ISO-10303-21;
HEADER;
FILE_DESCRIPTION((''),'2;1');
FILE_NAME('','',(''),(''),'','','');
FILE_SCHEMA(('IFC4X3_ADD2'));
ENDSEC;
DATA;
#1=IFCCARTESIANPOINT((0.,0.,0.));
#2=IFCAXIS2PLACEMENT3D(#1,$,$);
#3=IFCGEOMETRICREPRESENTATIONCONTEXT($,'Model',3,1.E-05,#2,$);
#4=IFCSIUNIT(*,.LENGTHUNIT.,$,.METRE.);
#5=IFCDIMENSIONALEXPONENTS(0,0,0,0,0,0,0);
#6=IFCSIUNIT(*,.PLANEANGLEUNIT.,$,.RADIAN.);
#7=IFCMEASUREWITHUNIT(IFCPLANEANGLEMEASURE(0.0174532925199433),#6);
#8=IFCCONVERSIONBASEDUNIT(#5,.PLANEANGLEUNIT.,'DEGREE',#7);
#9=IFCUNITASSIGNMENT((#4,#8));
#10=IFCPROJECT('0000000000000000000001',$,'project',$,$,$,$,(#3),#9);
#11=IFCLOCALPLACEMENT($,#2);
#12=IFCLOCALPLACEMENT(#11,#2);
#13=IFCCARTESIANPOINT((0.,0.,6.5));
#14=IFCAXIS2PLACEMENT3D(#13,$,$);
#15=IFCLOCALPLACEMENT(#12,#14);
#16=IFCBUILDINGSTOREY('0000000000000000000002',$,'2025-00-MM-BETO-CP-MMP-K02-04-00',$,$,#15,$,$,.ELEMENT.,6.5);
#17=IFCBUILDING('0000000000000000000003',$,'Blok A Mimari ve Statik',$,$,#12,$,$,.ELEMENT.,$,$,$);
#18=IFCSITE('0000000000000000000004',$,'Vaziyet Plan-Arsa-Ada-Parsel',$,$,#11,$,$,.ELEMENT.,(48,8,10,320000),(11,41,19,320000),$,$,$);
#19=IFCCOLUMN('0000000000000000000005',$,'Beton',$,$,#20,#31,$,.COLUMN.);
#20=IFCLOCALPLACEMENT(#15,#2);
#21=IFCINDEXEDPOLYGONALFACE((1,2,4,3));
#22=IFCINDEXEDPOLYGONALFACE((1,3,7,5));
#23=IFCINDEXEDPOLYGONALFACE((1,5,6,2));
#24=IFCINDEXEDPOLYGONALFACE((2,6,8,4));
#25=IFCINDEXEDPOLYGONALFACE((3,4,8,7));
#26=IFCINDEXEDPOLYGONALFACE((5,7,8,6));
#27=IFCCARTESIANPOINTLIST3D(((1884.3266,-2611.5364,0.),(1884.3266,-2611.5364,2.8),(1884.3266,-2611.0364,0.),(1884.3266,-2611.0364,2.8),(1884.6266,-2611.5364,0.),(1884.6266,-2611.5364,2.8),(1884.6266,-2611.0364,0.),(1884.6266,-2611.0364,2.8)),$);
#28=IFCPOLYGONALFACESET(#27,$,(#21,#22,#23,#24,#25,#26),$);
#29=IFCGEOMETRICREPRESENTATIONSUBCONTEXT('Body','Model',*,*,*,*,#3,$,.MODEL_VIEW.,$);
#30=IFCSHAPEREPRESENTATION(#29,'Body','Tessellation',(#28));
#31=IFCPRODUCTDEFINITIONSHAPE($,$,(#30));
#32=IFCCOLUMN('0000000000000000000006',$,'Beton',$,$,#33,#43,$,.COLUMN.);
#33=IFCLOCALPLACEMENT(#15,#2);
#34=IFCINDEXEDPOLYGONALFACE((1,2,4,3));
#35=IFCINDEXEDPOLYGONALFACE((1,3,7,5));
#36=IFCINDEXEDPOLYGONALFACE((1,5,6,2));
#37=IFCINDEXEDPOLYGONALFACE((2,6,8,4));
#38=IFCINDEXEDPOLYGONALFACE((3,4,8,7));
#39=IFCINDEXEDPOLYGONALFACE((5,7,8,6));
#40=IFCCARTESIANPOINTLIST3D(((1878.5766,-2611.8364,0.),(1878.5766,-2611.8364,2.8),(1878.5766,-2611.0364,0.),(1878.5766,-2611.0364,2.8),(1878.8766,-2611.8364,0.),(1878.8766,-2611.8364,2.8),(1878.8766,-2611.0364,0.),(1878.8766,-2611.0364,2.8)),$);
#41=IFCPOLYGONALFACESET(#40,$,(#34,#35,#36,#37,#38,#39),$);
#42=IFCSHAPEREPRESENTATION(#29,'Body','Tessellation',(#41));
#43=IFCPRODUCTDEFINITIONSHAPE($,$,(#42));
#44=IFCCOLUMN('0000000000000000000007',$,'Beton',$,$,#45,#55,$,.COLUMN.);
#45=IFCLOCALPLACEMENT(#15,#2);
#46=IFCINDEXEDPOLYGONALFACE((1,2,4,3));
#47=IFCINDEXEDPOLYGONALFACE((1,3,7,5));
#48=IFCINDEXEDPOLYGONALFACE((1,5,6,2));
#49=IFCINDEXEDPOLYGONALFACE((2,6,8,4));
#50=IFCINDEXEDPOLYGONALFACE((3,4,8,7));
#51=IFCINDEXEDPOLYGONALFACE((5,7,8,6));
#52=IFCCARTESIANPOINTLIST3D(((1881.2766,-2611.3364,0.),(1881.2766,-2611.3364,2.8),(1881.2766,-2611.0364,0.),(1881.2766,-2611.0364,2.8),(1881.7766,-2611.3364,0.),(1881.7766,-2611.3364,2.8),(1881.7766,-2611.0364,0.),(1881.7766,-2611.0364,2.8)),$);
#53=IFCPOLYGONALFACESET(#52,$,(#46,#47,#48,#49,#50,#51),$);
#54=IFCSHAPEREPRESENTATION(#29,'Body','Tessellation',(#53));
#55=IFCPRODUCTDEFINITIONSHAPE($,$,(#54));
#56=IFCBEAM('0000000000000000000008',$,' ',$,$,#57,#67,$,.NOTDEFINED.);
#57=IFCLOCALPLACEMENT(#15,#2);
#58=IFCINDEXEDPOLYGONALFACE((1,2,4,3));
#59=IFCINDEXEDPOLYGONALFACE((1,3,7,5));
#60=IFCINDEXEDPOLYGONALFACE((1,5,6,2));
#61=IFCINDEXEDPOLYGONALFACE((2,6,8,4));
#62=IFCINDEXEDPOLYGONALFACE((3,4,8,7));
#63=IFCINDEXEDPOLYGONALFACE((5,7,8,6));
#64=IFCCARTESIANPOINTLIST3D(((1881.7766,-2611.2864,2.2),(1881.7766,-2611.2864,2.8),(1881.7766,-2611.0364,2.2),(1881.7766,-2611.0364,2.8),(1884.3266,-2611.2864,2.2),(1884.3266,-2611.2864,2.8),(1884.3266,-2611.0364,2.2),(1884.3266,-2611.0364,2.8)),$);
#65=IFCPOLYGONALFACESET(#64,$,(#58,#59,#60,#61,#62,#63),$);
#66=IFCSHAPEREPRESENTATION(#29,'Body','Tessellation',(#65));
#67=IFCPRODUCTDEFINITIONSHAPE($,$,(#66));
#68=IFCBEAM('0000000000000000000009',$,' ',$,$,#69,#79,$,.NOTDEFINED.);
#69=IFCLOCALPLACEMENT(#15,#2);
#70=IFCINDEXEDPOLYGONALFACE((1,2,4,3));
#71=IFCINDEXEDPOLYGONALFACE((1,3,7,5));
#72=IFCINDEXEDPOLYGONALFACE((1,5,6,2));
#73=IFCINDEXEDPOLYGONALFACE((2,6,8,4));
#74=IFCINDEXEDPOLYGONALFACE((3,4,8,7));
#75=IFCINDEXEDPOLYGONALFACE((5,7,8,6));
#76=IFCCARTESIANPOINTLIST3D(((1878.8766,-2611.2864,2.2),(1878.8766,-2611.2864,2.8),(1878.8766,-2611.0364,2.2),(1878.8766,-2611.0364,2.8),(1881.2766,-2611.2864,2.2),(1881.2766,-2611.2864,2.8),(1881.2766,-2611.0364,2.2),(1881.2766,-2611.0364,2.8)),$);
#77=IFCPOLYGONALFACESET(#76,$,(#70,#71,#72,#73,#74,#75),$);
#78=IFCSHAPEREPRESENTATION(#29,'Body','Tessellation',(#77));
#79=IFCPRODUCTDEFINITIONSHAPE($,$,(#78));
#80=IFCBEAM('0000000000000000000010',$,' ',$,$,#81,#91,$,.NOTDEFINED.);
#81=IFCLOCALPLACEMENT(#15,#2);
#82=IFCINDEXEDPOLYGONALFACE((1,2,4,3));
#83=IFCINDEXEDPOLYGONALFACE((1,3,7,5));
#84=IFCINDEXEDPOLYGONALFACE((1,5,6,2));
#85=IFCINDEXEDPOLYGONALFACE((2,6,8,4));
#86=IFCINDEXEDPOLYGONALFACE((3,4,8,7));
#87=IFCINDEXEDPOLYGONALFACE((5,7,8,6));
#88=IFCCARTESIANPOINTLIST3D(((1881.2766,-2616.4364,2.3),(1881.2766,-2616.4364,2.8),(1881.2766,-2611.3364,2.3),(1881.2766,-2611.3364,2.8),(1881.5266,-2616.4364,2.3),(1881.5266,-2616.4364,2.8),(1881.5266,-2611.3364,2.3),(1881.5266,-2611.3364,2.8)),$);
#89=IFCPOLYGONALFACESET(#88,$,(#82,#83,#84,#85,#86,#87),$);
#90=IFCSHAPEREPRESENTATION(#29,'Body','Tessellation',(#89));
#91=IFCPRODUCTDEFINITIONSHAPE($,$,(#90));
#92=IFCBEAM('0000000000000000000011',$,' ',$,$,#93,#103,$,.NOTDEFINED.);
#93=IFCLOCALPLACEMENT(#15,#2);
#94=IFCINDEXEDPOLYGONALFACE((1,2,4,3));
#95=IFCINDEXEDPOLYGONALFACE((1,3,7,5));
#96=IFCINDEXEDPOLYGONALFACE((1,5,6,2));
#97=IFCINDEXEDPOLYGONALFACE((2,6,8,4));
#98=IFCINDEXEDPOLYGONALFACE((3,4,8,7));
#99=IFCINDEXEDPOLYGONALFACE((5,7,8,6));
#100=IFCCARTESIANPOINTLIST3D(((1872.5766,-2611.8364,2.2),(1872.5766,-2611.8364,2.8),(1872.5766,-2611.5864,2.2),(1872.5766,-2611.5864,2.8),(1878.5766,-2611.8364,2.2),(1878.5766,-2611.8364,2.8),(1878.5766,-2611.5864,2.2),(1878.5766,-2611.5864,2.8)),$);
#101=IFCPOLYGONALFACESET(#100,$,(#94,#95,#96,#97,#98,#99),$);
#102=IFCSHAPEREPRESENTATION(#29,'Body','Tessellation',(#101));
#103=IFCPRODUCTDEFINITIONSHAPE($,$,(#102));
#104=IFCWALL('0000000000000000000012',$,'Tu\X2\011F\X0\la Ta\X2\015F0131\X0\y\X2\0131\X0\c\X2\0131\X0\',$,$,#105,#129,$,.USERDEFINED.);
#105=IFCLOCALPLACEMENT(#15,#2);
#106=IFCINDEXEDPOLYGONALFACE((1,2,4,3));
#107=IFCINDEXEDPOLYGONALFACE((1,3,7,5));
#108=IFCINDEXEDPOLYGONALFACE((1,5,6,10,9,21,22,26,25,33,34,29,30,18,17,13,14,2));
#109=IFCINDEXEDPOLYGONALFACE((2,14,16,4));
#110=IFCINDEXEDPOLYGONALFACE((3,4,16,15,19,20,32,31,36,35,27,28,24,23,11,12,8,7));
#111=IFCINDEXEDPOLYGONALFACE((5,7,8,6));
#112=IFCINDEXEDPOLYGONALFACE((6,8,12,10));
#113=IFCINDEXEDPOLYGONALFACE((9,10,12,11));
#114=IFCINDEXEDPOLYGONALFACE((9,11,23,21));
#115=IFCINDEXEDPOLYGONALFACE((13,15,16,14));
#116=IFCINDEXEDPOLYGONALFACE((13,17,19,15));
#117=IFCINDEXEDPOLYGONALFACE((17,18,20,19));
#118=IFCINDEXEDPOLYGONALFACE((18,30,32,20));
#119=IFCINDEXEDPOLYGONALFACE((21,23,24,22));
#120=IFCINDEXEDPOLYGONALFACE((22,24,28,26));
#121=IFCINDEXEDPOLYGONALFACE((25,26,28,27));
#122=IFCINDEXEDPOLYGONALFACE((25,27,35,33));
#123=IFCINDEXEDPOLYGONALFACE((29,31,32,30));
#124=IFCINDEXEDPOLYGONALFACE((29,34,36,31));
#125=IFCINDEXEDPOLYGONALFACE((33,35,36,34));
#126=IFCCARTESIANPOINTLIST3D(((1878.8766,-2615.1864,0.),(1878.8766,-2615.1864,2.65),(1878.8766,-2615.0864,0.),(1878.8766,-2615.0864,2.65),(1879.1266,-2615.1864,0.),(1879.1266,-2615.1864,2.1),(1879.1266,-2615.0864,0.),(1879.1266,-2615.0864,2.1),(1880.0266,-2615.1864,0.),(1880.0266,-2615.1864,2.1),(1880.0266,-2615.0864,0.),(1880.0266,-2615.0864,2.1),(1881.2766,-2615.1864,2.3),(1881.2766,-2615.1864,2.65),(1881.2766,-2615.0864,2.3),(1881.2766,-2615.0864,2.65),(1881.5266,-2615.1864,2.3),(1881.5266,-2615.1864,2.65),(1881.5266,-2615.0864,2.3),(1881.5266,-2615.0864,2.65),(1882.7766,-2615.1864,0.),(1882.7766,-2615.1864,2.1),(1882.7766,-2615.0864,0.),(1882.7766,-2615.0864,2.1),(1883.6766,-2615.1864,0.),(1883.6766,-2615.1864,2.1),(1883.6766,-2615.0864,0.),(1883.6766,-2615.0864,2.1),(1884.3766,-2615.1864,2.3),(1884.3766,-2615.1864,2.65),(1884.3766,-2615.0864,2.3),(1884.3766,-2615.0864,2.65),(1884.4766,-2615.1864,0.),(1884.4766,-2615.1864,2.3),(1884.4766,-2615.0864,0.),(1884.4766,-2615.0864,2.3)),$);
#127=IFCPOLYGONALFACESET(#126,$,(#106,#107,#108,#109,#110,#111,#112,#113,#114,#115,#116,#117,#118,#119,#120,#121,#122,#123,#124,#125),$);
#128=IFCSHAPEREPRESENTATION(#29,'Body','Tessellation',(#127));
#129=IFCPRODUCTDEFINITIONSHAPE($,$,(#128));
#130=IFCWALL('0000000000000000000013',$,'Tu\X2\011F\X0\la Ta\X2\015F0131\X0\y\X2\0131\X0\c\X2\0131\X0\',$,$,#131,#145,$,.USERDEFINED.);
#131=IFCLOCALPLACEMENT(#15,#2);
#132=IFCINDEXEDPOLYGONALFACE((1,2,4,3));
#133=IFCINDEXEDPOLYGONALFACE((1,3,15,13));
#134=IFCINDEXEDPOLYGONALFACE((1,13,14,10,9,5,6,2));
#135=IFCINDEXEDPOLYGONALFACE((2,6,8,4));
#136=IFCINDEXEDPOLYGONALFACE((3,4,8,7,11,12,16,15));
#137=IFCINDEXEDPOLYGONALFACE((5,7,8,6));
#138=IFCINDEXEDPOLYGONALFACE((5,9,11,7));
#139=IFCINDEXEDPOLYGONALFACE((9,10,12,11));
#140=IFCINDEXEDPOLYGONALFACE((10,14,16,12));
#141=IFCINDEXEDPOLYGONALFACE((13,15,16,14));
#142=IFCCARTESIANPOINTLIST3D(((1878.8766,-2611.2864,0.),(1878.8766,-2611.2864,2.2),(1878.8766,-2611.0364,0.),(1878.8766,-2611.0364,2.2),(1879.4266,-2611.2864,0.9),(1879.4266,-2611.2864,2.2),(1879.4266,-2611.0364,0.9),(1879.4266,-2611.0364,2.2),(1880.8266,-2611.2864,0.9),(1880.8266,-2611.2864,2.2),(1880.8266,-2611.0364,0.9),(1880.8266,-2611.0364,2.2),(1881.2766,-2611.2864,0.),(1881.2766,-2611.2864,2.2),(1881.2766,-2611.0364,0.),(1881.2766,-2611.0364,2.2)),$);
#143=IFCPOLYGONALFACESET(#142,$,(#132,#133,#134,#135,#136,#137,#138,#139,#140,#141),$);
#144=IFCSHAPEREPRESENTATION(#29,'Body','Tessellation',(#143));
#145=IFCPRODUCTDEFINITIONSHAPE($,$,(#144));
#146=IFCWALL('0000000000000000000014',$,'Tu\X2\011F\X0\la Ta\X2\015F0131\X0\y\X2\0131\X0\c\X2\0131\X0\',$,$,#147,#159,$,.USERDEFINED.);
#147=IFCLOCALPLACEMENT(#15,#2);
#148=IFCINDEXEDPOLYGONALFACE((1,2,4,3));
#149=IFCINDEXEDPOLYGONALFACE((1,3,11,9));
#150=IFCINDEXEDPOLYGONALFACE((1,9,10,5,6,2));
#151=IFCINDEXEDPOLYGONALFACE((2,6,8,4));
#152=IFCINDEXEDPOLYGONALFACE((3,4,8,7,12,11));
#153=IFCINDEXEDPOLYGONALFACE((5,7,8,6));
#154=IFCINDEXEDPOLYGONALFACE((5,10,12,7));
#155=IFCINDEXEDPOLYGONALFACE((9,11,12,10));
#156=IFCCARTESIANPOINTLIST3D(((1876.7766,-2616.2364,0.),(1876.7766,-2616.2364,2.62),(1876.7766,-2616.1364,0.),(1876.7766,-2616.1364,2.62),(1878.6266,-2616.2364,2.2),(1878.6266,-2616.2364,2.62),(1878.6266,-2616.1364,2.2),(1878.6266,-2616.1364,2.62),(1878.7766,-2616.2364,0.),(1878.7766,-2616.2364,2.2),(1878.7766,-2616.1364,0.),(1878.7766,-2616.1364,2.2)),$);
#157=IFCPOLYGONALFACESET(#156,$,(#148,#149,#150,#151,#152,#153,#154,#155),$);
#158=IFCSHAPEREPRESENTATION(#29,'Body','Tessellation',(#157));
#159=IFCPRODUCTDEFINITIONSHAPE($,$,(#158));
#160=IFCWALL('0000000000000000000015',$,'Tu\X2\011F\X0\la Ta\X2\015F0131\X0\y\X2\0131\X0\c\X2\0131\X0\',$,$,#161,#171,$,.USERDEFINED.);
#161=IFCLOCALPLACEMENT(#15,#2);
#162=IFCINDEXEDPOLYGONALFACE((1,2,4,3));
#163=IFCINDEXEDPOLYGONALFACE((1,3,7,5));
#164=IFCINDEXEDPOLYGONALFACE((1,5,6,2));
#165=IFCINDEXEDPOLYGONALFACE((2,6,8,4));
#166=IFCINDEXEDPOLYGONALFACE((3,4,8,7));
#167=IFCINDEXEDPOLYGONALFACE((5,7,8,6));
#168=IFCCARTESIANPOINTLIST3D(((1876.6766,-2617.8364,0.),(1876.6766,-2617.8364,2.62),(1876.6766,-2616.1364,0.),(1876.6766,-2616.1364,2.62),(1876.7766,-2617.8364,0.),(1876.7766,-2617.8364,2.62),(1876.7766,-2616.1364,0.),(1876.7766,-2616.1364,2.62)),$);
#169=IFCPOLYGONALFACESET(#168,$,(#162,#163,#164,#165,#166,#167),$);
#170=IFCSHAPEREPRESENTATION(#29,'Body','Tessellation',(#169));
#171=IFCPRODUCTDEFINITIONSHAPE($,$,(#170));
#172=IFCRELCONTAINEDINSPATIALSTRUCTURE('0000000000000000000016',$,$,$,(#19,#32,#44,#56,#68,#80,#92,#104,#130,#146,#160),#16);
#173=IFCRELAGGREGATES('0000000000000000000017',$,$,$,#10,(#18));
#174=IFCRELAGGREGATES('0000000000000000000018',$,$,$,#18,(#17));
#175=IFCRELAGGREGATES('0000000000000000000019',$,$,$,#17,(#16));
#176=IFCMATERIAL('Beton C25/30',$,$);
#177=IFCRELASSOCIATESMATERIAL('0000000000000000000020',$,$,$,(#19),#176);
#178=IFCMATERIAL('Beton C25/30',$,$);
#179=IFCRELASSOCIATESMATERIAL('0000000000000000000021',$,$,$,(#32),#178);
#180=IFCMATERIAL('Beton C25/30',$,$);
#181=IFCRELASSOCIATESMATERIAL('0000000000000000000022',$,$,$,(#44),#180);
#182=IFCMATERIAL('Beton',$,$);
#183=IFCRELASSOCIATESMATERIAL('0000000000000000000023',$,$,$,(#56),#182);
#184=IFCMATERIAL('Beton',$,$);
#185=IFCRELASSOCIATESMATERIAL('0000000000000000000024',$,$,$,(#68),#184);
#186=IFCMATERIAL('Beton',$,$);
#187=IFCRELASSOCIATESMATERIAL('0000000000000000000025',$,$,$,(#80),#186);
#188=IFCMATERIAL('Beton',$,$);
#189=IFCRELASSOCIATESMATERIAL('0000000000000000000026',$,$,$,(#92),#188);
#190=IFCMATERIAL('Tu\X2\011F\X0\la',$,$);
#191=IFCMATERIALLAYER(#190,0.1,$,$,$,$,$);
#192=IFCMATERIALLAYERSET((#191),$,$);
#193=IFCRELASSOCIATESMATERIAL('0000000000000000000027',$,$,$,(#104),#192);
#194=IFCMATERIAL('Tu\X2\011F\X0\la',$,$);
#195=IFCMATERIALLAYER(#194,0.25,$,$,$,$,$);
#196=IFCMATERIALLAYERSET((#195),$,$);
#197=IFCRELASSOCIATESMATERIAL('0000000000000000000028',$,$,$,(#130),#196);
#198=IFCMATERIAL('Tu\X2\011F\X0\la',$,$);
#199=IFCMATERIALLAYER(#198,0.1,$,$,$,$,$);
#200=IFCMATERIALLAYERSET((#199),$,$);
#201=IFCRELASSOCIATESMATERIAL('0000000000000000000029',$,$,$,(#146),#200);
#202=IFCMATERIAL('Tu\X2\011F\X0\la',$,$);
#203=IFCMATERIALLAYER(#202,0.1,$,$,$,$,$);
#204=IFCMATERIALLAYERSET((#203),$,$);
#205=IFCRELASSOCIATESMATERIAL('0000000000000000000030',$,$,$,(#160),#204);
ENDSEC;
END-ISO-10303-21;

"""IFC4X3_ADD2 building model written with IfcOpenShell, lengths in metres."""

from ifc_helpers import new_model, entity, si_unit, converted_unit, frame, frame_2d, origin, origin_with_axes, place, context, subcontext, project, spatial, polyline, rectangle, outline, extrude, clip, bounded_halfspace, material, layer, layer_set, layer_usage, element, save


model = new_model("IFC4X3_ADD2")

# Units and contexts
model_context = context("Model", 3, precision=1e-05, world=origin())
body_context = subcontext(model_context, "Body", "Model", "MODEL_VIEW")
ifc_project = project(units=[si_unit("LENGTHUNIT", "METRE"), converted_unit("PLANEANGLEUNIT", "DEGREE", entity("IfcPlaneAngleMeasure", 0.0174532925199433), si_unit("PLANEANGLEUNIT", "RADIAN"), dimensions=[0, 0, 0, 0, 0, 0, 0])], contexts=[model_context])

# Site, building, storey
site_placement = place(None, origin())
site = spatial("IfcSite", under=ifc_project, at=site_placement, Name="Vaziyet Plan-Arsa-Ada-Parsel", CompositionType="ELEMENT", RefLatitude=(48, 8, 10, 320000), RefLongitude=(11, 41, 19, 320000))
building_placement = place(site_placement, origin())
building = spatial("IfcBuilding", under=site, at=building_placement, Name="Blok A Mimari ve Statik", CompositionType="ELEMENT")
storey_placement = place(building_placement, frame((0.0, 0.0, 6.5)))
storey = spatial("IfcBuildingStorey", under=building, at=storey_placement, Name="2025-00-MM-BETO-CP-MMP-K02-04-00", CompositionType="ELEMENT", Elevation=6.5)

# Columns
ifc_material_1 = material(Name="Beton C25/30")
column_1_placement = place(storey_placement, frame((1884.3266, -2611.5364, 0.0)))
element("IfcColumn", 1, at=column_1_placement, inside=storey, material=ifc_material_1, Name="Beton", PredefinedType="COLUMN", context=body_context, shape_type="SweptSolid", body=[
    extrude(outline(polyline([(0.0, 0.5), (0.0, 0.0), (0.3, 0.0), (0.3, 0.5), (0.0, 0.5)])), origin_with_axes(), (0.0, 0.0, 1.0), 2.8),
])
ifc_material_2 = material(Name="Beton C25/30")
column_2_placement = place(storey_placement, frame((1878.5766, -2611.8364, 0.0)))
element("IfcColumn", 2, at=column_2_placement, inside=storey, material=ifc_material_2, Name="Beton", PredefinedType="COLUMN", context=body_context, shape_type="SweptSolid", body=[
    extrude(outline(polyline([(0.0, 0.0), (0.3, 0.0), (0.3, 0.8), (0.0, 0.8), (0.0, 0.0)])), origin_with_axes(), (0.0, 0.0, 1.0), 2.8),
])
ifc_material_3 = material(Name="Beton C25/30")
column_3_placement = place(storey_placement, frame((1881.2766, -2611.3364, 0.0)))
element("IfcColumn", 3, at=column_3_placement, inside=storey, material=ifc_material_3, Name="Beton", PredefinedType="COLUMN", context=body_context, shape_type="SweptSolid", body=[
    extrude(outline(polyline([(0.0, 0.3), (0.0, 0.0), (0.5, 0.0), (0.5, 0.3), (0.0, 0.3)])), origin_with_axes(), (0.0, 0.0, 1.0), 2.8),
])

# Beams
ifc_material_4 = material(Name="Beton")
beam_1_placement = place(storey_placement, frame((1884.3266, -2611.0364, 2.2), z_axis=(0.0, 0.0, 1.0), x_axis=(-1.0, 0.0, 0.0)))
element("IfcBeam", 4, at=beam_1_placement, inside=storey, material=ifc_material_4, Name=" ", PredefinedType="NOTDEFINED", context=body_context, shape_type="SweptSolid", body=[
    extrude(rectangle(XDim=0.25, YDim=0.6, at=frame_2d((0.125, 0.3), x_axis=(1.0, 0.0))), frame((0.0, 0.0, 0.0), z_axis=(1.0, 0.0, 0.0), x_axis=(0.0, 1.0, 0.0)), (0.0, 0.0, 1.0), 2.55),
])
ifc_material_5 = material(Name="Beton")
beam_2_placement = place(storey_placement, frame((1881.2766, -2611.0364, 2.2), z_axis=(0.0, 0.0, 1.0), x_axis=(-1.0, 0.0, 0.0)))
element("IfcBeam", 5, at=beam_2_placement, inside=storey, material=ifc_material_5, Name=" ", PredefinedType="NOTDEFINED", context=body_context, shape_type="SweptSolid", body=[
    extrude(rectangle(XDim=0.25, YDim=0.6, at=frame_2d((0.125, 0.3), x_axis=(1.0, 0.0))), frame((0.0, 0.0, 0.0), z_axis=(1.0, 0.0, 0.0), x_axis=(0.0, 1.0, 0.0)), (0.0, 0.0, 1.0), 2.4),
])
ifc_material_6 = material(Name="Beton")
beam_3_placement = place(storey_placement, frame((1881.2766, -2611.3364, 2.3), z_axis=(0.0, 0.0, 1.0), x_axis=(0.0, -1.0, 0.0)))
element("IfcBeam", 6, at=beam_3_placement, inside=storey, material=ifc_material_6, Name=" ", PredefinedType="NOTDEFINED", context=body_context, shape_type="SweptSolid", body=[
    extrude(rectangle(XDim=0.25, YDim=0.5, at=frame_2d((0.125, 0.25), x_axis=(1.0, 0.0))), frame((0.0, 0.0, 0.0), z_axis=(1.0, 0.0, 0.0), x_axis=(0.0, 1.0, 0.0)), (0.0, 0.0, 1.0), 5.1),
])
ifc_material_7 = material(Name="Beton")
beam_4_placement = place(storey_placement, frame((1878.5766, -2611.5864, 2.2), z_axis=(0.0, 0.0, 1.0), x_axis=(-1.0, 0.0, 0.0)))
element("IfcBeam", 7, at=beam_4_placement, inside=storey, material=ifc_material_7, Name=" ", PredefinedType="NOTDEFINED", context=body_context, shape_type="SweptSolid", body=[
    extrude(rectangle(XDim=0.25, YDim=0.6, at=frame_2d((0.125, 0.3), x_axis=(1.0, 0.0))), frame((0.0, 0.0, 0.0), z_axis=(1.0, 0.0, 0.0), x_axis=(0.0, 1.0, 0.0)), (0.0, 0.0, 1.0), 6.0),
])

# Wall, openings
ifc_material_8 = material(Name="Tuğla")
ifc_layer_1 = layer(ifc_material_8, 0.1)
ifc_layer_set_1 = layer_set([ifc_layer_1])
ifc_layer_usage_1 = layer_usage(ifc_layer_set_1, "AXIS2", "POSITIVE", 0.0)
wall_1_placement = place(storey_placement, frame((1878.8766, -2615.1864, 0.0), z_axis=(0.0, 0.0, 1.0), x_axis=(1.0, 0.0, 0.0)))
wall_1 = element("IfcWall", 8, at=wall_1_placement, inside=storey, material=ifc_layer_usage_1, Name="Tuğla Taşıyıcı", PredefinedType="USERDEFINED", context=body_context, shape_type="Clipping", body=[
    clip(clip(extrude(rectangle(XDim=5.6, YDim=0.1, at=frame_2d((2.8, 0.05), x_axis=(1.0, 0.0))), origin_with_axes(), (0.0, 0.0, 1.0), 2.65), bounded_halfspace(frame((2.525, 0.05, 2.3), z_axis=(0.0, 0.0, -1.0), x_axis=(0.0, -1.0, 0.0)), True, origin_with_axes(), polyline([(2.4, 0.1), (2.4, 0.0), (2.65, 0.0), (2.65, 0.1), (2.4, 0.1)]))), bounded_halfspace(frame((5.55, 0.05, 2.3), z_axis=(0.0, 0.0, -1.0), x_axis=(0.0, -1.0, 0.0)), True, origin_with_axes(), polyline([(5.5, 0.1), (5.5, 0.0), (5.6, 0.0), (5.6, 0.1), (5.5, 0.1)]))),
])
opening_1_placement = place(wall_1_placement, frame((0.25, 0.0, 0.0), z_axis=(0.0, 1.0, 0.0), x_axis=(0.0, 0.0, 1.0)))
element("IfcOpeningElement", 9, at=opening_1_placement, cuts=wall_1, PredefinedType="OPENING", context=body_context, shape_type="SweptSolid", body=[
    extrude(outline(polyline([(2.1, 0.9), (2.1, 0.0), (0.0, 0.0), (0.0, 0.9), (2.1, 0.9)])), origin_with_axes(), (0.0, 0.0, 1.0), 0.1),
])
opening_2_placement = place(wall_1_placement, frame((3.9, 0.0, 0.0), z_axis=(0.0, 1.0, 0.0), x_axis=(0.0, 0.0, 1.0)))
element("IfcOpeningElement", 10, at=opening_2_placement, cuts=wall_1, PredefinedType="OPENING", context=body_context, shape_type="SweptSolid", body=[
    extrude(outline(polyline([(2.1, 0.9), (2.1, 0.0), (0.0, 0.0), (0.0, 0.9), (2.1, 0.9)])), origin_with_axes(), (0.0, 0.0, 1.0), 0.1),
])

# Wall, opening
ifc_material_9 = material(Name="Tuğla")
ifc_layer_2 = layer(ifc_material_9, 0.25)
ifc_layer_set_2 = layer_set([ifc_layer_2])
ifc_layer_usage_2 = layer_usage(ifc_layer_set_2, "AXIS2", "POSITIVE", 0.0)
wall_2_placement = place(storey_placement, frame((1881.2766, -2611.0364, 0.0), z_axis=(0.0, 0.0, 1.0), x_axis=(-1.0, 0.0, 0.0)))
wall_2 = element("IfcWall", 11, at=wall_2_placement, inside=storey, material=ifc_layer_usage_2, Name="Tuğla Taşıyıcı", PredefinedType="USERDEFINED", context=body_context, shape_type="SweptSolid", body=[
    extrude(rectangle(XDim=2.4, YDim=0.25, at=frame_2d((1.2, 0.125), x_axis=(1.0, 0.0))), origin_with_axes(), (0.0, 0.0, 1.0), 2.2),
])
opening_3_placement = place(wall_2_placement, frame((0.45, 0.0, 0.9), z_axis=(0.0, 1.0, 0.0), x_axis=(0.0, 0.0, 1.0)))
element("IfcOpeningElement", 12, at=opening_3_placement, cuts=wall_2, PredefinedType="OPENING", context=body_context, shape_type="SweptSolid", body=[
    extrude(outline(polyline([(1.35, 1.4), (1.35, 0.0), (0.0, 0.0), (0.0, 1.4), (1.35, 1.4)])), origin_with_axes(), (0.0, 0.0, 1.0), 0.25),
])

# Walls
ifc_material_10 = material(Name="Tuğla")
ifc_layer_3 = layer(ifc_material_10, 0.1)
ifc_layer_set_3 = layer_set([ifc_layer_3])
ifc_layer_usage_3 = layer_usage(ifc_layer_set_3, "AXIS2", "POSITIVE", 0.0)
wall_3_placement = place(storey_placement, frame((1876.7766, -2616.2364, 0.0)))
element("IfcWall", 13, at=wall_3_placement, inside=storey, material=ifc_layer_usage_3, Name="Tuğla Taşıyıcı", PredefinedType="USERDEFINED", context=body_context, shape_type="Clipping", body=[
    clip(extrude(rectangle(XDim=2.0, YDim=0.1, at=frame_2d((1.0, 0.05), x_axis=(1.0, 0.0))), origin_with_axes(), (0.0, 0.0, 1.0), 2.62), bounded_halfspace(frame((1.925, 0.05, 2.2), z_axis=(0.0, 0.0, -1.0), x_axis=(0.0, -1.0, 0.0)), True, origin_with_axes(), polyline([(1.85, 0.1), (1.85, 0.0), (2.0, 0.0), (2.0, 0.1), (1.85, 0.1)]))),
])
ifc_material_11 = material(Name="Tuğla")
ifc_layer_4 = layer(ifc_material_11, 0.1)
ifc_layer_set_4 = layer_set([ifc_layer_4])
ifc_layer_usage_4 = layer_usage(ifc_layer_set_4, "AXIS2", "POSITIVE", 0.0)
wall_4_placement = place(storey_placement, frame((1876.6766, -2616.1364, 0.0), z_axis=(0.0, 0.0, 1.0), x_axis=(0.0, -1.0, 0.0)))
element("IfcWall", 14, at=wall_4_placement, inside=storey, material=ifc_layer_usage_4, Name="Tuğla Taşıyıcı", PredefinedType="USERDEFINED", context=body_context, shape_type="SweptSolid", body=[
    extrude(rectangle(XDim=1.7, YDim=0.1, at=frame_2d((0.85, 0.05), x_axis=(1.0, 0.0))), origin_with_axes(), (0.0, 0.0, 1.0), 2.62),
])

save(model, "model.ifc")
